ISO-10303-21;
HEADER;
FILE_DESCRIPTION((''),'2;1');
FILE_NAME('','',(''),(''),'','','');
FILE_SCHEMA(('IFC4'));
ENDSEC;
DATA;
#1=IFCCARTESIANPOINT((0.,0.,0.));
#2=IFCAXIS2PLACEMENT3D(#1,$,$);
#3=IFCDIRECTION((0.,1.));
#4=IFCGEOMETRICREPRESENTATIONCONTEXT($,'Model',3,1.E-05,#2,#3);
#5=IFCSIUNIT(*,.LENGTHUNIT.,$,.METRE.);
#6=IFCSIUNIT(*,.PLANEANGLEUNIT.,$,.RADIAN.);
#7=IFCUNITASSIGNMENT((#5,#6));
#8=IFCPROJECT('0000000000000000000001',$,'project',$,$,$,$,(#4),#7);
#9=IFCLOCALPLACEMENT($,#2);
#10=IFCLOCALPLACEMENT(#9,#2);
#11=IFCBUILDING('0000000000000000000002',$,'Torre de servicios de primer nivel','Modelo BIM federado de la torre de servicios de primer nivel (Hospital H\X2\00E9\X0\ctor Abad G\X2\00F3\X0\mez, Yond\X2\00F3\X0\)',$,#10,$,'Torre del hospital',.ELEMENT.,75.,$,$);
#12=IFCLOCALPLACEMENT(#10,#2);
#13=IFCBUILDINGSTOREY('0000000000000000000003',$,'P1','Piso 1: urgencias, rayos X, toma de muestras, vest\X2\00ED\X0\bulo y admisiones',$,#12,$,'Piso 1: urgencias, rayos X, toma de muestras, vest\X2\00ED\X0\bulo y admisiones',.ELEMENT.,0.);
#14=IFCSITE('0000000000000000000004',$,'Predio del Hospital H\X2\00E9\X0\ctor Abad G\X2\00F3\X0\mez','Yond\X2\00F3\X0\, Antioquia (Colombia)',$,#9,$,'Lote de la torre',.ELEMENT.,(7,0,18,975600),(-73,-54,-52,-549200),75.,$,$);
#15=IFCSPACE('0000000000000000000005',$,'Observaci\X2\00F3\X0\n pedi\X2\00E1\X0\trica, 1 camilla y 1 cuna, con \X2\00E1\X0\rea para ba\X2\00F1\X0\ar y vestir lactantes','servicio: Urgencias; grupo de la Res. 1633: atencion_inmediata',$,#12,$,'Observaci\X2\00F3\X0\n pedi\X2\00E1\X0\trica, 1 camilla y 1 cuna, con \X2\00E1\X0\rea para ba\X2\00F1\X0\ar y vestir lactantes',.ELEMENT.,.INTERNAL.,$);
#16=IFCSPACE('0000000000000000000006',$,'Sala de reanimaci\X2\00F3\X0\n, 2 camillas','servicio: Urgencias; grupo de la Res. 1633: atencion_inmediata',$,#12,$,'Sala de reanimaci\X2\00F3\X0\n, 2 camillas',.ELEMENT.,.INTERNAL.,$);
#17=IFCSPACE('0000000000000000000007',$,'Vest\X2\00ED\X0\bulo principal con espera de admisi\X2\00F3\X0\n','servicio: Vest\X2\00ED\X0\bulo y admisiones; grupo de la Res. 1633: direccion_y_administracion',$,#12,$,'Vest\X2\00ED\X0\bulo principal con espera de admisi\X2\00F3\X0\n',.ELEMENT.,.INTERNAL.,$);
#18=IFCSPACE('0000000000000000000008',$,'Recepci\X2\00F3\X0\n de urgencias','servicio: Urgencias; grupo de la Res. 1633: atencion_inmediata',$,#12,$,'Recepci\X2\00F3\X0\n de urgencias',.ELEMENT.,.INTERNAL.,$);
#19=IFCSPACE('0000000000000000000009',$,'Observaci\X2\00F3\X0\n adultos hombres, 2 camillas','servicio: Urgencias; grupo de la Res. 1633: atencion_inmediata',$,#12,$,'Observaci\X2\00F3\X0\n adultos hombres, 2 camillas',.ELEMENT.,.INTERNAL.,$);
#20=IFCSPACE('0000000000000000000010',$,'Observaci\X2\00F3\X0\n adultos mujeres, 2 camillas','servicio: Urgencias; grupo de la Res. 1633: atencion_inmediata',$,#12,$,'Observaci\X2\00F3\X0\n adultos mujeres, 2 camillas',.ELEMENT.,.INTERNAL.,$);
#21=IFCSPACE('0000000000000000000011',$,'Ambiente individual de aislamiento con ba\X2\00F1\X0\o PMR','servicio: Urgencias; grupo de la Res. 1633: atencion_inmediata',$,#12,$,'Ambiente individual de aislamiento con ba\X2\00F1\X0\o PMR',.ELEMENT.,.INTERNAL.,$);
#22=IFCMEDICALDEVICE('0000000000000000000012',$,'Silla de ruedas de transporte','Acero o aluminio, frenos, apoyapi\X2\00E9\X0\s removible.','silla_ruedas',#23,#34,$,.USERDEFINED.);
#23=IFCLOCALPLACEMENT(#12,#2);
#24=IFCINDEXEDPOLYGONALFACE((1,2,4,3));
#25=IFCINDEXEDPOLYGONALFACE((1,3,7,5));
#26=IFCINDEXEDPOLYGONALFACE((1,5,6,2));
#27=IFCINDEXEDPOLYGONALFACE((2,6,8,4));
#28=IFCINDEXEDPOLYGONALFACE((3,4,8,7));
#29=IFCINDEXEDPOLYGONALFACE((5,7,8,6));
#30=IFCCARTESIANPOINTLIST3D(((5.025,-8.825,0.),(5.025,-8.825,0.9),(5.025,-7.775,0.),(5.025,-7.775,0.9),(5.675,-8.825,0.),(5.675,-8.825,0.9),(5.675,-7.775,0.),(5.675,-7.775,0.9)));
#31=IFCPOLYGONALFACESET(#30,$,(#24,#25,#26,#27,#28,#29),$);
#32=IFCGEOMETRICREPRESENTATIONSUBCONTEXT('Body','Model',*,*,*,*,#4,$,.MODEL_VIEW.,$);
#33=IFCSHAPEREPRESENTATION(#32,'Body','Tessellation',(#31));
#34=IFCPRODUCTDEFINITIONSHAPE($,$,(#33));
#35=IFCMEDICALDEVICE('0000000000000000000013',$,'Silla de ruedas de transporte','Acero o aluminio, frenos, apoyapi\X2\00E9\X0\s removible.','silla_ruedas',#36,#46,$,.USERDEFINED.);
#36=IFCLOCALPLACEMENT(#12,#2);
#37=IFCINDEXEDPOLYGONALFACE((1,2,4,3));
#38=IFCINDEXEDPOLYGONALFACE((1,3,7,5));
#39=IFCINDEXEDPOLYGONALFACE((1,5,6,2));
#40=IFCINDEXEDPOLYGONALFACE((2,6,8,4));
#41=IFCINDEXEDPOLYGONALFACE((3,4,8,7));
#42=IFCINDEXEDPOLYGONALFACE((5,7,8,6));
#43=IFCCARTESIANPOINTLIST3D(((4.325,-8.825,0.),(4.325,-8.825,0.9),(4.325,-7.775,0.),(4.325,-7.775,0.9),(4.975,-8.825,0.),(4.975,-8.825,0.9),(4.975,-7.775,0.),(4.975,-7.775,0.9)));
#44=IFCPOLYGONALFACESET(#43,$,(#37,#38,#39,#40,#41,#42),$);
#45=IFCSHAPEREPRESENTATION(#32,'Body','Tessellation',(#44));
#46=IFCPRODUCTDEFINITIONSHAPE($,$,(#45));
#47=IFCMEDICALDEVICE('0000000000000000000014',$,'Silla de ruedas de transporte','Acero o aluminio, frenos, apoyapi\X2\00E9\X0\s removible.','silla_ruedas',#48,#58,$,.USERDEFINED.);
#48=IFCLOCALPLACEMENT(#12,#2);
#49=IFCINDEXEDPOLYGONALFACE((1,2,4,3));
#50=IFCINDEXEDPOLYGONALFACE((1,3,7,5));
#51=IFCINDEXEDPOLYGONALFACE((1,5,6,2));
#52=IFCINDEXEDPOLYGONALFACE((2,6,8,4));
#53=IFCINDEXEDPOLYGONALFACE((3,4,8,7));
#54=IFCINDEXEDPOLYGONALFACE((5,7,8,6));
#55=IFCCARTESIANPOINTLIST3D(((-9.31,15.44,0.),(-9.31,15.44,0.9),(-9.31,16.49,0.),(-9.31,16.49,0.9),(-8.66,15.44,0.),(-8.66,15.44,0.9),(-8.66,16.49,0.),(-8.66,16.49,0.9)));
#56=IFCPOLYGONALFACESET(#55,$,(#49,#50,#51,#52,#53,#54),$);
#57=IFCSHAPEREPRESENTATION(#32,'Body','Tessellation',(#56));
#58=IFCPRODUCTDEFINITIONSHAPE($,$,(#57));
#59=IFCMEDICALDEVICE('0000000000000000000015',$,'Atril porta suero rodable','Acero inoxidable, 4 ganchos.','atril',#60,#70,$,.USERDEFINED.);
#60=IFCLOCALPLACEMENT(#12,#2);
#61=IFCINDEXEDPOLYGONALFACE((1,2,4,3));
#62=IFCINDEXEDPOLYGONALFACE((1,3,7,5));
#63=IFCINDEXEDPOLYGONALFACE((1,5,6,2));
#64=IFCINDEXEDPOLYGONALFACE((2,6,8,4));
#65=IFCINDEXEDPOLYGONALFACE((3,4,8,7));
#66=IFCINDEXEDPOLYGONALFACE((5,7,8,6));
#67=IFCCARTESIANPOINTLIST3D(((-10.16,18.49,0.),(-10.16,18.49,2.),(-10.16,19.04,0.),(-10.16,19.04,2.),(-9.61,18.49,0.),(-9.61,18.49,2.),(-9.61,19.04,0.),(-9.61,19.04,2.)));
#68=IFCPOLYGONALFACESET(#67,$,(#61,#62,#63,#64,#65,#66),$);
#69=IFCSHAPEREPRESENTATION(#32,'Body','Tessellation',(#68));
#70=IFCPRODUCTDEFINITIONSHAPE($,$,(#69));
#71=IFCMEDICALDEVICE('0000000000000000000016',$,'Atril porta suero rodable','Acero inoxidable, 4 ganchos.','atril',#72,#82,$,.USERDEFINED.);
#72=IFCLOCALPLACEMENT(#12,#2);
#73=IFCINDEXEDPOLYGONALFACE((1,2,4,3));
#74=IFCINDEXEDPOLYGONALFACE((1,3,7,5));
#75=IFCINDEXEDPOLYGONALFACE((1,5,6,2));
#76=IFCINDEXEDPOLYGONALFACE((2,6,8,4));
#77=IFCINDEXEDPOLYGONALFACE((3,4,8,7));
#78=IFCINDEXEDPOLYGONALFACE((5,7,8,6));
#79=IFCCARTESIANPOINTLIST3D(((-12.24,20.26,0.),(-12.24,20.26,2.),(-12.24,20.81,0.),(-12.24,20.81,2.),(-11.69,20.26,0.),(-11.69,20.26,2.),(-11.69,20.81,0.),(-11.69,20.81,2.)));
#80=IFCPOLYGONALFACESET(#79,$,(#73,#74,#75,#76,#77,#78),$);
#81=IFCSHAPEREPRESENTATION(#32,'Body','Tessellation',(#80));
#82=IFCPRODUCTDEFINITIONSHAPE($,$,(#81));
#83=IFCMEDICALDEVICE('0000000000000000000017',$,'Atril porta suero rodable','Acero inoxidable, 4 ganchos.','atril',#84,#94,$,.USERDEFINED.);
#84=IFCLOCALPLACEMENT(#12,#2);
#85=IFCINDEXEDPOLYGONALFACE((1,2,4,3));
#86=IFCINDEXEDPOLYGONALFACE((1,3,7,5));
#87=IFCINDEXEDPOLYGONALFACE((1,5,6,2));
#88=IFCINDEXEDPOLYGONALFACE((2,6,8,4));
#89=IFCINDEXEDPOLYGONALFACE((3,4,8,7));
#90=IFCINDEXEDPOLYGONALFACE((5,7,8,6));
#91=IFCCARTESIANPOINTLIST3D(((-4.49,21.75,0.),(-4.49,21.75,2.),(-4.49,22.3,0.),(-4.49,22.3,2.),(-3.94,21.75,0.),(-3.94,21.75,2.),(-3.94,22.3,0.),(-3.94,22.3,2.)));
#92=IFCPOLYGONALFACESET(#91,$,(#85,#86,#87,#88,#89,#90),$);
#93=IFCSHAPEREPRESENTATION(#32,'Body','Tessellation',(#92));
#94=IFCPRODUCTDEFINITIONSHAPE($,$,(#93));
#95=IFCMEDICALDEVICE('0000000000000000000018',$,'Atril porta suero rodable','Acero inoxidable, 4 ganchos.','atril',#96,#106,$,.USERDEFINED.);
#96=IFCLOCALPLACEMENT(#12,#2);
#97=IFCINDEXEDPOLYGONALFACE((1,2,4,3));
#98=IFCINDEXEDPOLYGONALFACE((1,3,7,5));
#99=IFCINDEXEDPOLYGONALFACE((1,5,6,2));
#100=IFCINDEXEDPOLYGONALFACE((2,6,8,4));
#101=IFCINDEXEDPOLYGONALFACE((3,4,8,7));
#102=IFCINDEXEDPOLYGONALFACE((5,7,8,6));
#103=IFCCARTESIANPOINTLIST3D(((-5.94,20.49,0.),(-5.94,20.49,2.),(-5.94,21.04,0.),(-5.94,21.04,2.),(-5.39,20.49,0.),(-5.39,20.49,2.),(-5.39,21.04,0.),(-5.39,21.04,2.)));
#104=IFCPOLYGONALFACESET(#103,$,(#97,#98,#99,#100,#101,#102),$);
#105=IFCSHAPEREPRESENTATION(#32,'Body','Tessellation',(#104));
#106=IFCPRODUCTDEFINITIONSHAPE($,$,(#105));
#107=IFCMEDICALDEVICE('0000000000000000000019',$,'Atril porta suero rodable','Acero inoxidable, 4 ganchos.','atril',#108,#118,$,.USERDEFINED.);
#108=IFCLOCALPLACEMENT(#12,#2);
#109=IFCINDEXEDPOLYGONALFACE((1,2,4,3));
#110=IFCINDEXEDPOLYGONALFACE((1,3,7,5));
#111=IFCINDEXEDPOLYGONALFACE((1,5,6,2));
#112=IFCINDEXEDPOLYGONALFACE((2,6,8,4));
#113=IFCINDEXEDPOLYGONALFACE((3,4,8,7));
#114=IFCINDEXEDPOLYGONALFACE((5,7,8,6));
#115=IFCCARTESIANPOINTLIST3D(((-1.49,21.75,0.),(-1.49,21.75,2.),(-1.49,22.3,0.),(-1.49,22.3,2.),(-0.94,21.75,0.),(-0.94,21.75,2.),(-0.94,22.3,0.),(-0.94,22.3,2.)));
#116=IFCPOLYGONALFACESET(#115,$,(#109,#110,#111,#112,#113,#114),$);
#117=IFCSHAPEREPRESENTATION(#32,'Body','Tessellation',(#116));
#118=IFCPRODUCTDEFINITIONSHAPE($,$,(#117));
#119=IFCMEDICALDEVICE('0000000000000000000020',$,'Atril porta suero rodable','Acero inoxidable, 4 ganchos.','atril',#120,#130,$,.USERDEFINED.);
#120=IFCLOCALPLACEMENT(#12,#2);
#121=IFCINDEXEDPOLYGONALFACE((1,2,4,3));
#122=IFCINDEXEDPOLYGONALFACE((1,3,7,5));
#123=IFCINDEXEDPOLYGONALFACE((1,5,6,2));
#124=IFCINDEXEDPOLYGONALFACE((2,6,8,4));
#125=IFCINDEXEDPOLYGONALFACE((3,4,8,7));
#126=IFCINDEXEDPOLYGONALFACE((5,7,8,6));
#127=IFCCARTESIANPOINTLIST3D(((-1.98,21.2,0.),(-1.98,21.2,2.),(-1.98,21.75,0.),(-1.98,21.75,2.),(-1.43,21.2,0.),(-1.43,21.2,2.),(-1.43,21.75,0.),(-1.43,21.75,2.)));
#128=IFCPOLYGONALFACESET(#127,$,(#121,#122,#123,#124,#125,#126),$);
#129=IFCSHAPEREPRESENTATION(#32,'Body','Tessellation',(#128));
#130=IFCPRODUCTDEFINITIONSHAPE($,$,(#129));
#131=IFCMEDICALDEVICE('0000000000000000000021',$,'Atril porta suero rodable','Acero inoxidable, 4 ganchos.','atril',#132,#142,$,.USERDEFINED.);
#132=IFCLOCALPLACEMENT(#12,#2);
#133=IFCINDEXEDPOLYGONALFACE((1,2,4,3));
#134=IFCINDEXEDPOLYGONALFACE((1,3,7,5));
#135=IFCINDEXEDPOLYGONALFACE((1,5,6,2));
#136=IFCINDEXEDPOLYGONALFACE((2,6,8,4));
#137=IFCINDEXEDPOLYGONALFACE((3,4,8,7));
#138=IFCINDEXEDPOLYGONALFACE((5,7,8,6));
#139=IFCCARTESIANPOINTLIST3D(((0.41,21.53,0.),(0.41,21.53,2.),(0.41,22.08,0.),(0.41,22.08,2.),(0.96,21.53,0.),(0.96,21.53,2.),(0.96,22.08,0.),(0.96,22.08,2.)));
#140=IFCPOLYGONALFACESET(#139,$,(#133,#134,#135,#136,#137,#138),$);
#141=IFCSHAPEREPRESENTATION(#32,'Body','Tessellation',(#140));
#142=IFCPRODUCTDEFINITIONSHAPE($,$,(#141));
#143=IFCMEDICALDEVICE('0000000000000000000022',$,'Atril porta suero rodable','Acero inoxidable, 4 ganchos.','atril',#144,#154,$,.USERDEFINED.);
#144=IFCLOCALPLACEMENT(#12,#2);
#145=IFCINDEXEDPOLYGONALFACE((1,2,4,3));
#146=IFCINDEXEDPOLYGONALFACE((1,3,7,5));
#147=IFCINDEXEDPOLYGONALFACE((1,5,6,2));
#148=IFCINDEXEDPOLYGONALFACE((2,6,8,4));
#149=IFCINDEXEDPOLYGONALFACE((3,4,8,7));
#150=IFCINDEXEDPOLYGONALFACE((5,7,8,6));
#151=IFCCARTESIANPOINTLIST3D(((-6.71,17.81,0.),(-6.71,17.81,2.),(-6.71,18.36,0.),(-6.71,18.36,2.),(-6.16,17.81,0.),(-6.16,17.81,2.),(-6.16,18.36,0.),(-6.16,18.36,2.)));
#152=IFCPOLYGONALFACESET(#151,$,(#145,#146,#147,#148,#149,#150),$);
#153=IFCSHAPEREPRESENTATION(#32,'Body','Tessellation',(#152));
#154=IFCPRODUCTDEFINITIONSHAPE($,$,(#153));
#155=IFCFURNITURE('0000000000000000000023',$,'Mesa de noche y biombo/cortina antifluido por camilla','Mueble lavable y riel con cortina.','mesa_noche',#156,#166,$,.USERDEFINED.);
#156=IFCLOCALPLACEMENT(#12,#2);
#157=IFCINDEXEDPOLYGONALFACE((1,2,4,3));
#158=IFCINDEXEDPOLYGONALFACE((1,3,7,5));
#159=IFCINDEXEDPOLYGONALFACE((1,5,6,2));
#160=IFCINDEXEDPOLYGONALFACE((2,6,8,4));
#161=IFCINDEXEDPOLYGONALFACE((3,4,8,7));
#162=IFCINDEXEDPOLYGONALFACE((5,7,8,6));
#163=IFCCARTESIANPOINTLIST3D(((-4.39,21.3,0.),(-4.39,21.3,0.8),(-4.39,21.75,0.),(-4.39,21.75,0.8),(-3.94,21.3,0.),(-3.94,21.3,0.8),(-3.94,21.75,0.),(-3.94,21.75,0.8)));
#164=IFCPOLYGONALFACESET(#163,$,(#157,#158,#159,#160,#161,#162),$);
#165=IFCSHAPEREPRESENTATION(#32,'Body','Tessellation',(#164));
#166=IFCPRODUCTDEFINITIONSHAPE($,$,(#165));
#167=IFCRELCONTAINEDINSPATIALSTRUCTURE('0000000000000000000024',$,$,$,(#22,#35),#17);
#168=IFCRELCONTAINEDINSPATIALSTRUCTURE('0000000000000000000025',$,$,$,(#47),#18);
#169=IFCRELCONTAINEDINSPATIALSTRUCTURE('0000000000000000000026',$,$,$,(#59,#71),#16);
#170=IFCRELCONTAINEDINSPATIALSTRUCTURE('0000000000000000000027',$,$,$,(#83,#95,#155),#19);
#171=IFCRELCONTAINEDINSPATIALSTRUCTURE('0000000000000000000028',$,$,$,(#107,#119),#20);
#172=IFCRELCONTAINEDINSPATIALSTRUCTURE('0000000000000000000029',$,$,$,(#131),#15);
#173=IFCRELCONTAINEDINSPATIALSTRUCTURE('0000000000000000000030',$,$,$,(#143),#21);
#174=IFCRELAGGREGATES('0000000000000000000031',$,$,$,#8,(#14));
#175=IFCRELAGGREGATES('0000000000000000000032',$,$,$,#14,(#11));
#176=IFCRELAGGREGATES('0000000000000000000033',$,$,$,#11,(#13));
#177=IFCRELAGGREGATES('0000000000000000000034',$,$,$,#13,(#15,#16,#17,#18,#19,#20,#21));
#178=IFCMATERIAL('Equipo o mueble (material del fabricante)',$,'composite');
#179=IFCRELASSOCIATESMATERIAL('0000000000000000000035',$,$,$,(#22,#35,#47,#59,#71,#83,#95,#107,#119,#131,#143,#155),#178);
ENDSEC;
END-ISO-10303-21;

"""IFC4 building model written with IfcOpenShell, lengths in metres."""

from ifc_helpers import new_model, si_unit, direction, frame, origin, place, context, subcontext, project, spatial, rectangle, extrude, material, element, save


model = new_model("IFC4")

# Units and contexts
model_context = context("Model", 3, precision=1e-05, world=origin(), true_north=direction((0.0, 1.0)))
body_context = subcontext(model_context, "Body", "Model", "MODEL_VIEW")
ifc_project = project(units=[si_unit("LENGTHUNIT", "METRE"), si_unit("PLANEANGLEUNIT", "RADIAN")], contexts=[model_context])

# Site, building, storey
site_placement = place(None, origin())
site = spatial("IfcSite", under=ifc_project, at=site_placement, Name="Predio del Hospital Héctor Abad Gómez", Description="Yondó, Antioquia (Colombia)", LongName="Lote de la torre", CompositionType="ELEMENT", RefLatitude=(7, 0, 18, 975600), RefLongitude=(-73, -54, -52, -549200), RefElevation=75.0)
building_placement = place(site_placement, origin())
building = spatial("IfcBuilding", under=site, at=building_placement, Name="Torre de servicios de primer nivel", Description="Modelo BIM federado de la torre de servicios de primer nivel (Hospital Héctor Abad Gómez, Yondó)", LongName="Torre del hospital", CompositionType="ELEMENT", ElevationOfRefHeight=75.0)
placement = place(building_placement, origin())
storey = spatial("IfcBuildingStorey", under=building, at=placement, Name="P1", Description="Piso 1: urgencias, rayos X, toma de muestras, vestíbulo y admisiones", LongName="Piso 1: urgencias, rayos X, toma de muestras, vestíbulo y admisiones", CompositionType="ELEMENT", Elevation=0.0)

# Shared definitions
ifc_material = material(Name="Equipo o mueble (material del fabricante)", Category="composite")

# Shared definitions
space_1 = spatial("IfcSpace", under=storey, at=placement, Name="Observación pediátrica, 1 camilla y 1 cuna, con área para bañar y vestir lactantes", Description="servicio: Urgencias; grupo de la Res. 1633: atencion_inmediata", LongName="Observación pediátrica, 1 camilla y 1 cuna, con área para bañar y vestir lactantes", CompositionType="ELEMENT", PredefinedType="INTERNAL")

# Shared definitions
space_2 = spatial("IfcSpace", under=storey, at=placement, Name="Sala de reanimación, 2 camillas", Description="servicio: Urgencias; grupo de la Res. 1633: atencion_inmediata", LongName="Sala de reanimación, 2 camillas", CompositionType="ELEMENT", PredefinedType="INTERNAL")

# Shared definitions
space_3 = spatial("IfcSpace", under=storey, at=placement, Name="Vestíbulo principal con espera de admisión", Description="servicio: Vestíbulo y admisiones; grupo de la Res. 1633: direccion_y_administracion", LongName="Vestíbulo principal con espera de admisión", CompositionType="ELEMENT", PredefinedType="INTERNAL")

# Medical devices
element("IfcMedicalDevice", 1, at=placement, inside=space_3, material=ifc_material, Name="Silla de ruedas de transporte", Description="Acero o aluminio, frenos, apoyapiés removible.", ObjectType="silla_ruedas", PredefinedType="USERDEFINED", context=body_context, shape_type="SweptSolid", body=[
    extrude(rectangle(XDim=0.65, YDim=1.05), frame((5.35, -8.3, 0.0), z_axis=(0.0, 0.0, 1.0), x_axis=(-1.0, 0.0, 0.0)), (0.0, 0.0, 1.0), 0.9),
])
element("IfcMedicalDevice", 2, at=placement, inside=space_3, material=ifc_material, Name="Silla de ruedas de transporte", Description="Acero o aluminio, frenos, apoyapiés removible.", ObjectType="silla_ruedas", PredefinedType="USERDEFINED", context=body_context, shape_type="SweptSolid", body=[
    extrude(rectangle(XDim=0.65, YDim=1.05), frame((4.65, -8.3, 0.0), z_axis=(0.0, 0.0, 1.0), x_axis=(-1.0, 0.0, 0.0)), (0.0, 0.0, 1.0), 0.9),
])

# Shared definitions
space_4 = spatial("IfcSpace", under=storey, at=placement, Name="Recepción de urgencias", Description="servicio: Urgencias; grupo de la Res. 1633: atencion_inmediata", LongName="Recepción de urgencias", CompositionType="ELEMENT", PredefinedType="INTERNAL")

# Medical devices
element("IfcMedicalDevice", 3, at=placement, inside=space_4, material=ifc_material, Name="Silla de ruedas de transporte", Description="Acero o aluminio, frenos, apoyapiés removible.", ObjectType="silla_ruedas", PredefinedType="USERDEFINED", context=body_context, shape_type="SweptSolid", body=[
    extrude(rectangle(XDim=0.65, YDim=1.05), frame((-8.985, 15.965, 0.0), z_axis=(0.0, 0.0, 1.0), x_axis=(-1.0, 0.0, 0.0)), (0.0, 0.0, 1.0), 0.9),
])
element("IfcMedicalDevice", 4, at=placement, inside=space_2, material=ifc_material, Name="Atril porta suero rodable", Description="Acero inoxidable, 4 ganchos.", ObjectType="atril", PredefinedType="USERDEFINED", context=body_context, shape_type="SweptSolid", body=[
    extrude(rectangle(XDim=0.55, YDim=0.55), frame((-9.885, 18.765, 0.0), z_axis=(0.0, 0.0, 1.0), x_axis=(0.0, 1.0, 0.0)), (0.0, 0.0, 1.0), 2.0),
])
element("IfcMedicalDevice", 5, at=placement, inside=space_2, material=ifc_material, Name="Atril porta suero rodable", Description="Acero inoxidable, 4 ganchos.", ObjectType="atril", PredefinedType="USERDEFINED", context=body_context, shape_type="SweptSolid", body=[
    extrude(rectangle(XDim=0.55, YDim=0.55), frame((-11.965, 20.535, 0.0), z_axis=(0.0, 0.0, 1.0), x_axis=(0.0, 1.0, 0.0)), (0.0, 0.0, 1.0), 2.0),
])

# Shared definitions
space_5 = spatial("IfcSpace", under=storey, at=placement, Name="Observación adultos hombres, 2 camillas", Description="servicio: Urgencias; grupo de la Res. 1633: atencion_inmediata", LongName="Observación adultos hombres, 2 camillas", CompositionType="ELEMENT", PredefinedType="INTERNAL")

# Medical devices
element("IfcMedicalDevice", 6, at=placement, inside=space_5, material=ifc_material, Name="Atril porta suero rodable", Description="Acero inoxidable, 4 ganchos.", ObjectType="atril", PredefinedType="USERDEFINED", context=body_context, shape_type="SweptSolid", body=[
    extrude(rectangle(XDim=0.55, YDim=0.55), frame((-4.215, 22.025, 0.0), z_axis=(0.0, 0.0, 1.0), x_axis=(-1.0, 0.0, 0.0)), (0.0, 0.0, 1.0), 2.0),
])
element("IfcMedicalDevice", 7, at=placement, inside=space_5, material=ifc_material, Name="Atril porta suero rodable", Description="Acero inoxidable, 4 ganchos.", ObjectType="atril", PredefinedType="USERDEFINED", context=body_context, shape_type="SweptSolid", body=[
    extrude(rectangle(XDim=0.55, YDim=0.55), frame((-5.665, 20.765, 0.0)), (0.0, 0.0, 1.0), 2.0),
])

# Shared definitions
space_6 = spatial("IfcSpace", under=storey, at=placement, Name="Observación adultos mujeres, 2 camillas", Description="servicio: Urgencias; grupo de la Res. 1633: atencion_inmediata", LongName="Observación adultos mujeres, 2 camillas", CompositionType="ELEMENT", PredefinedType="INTERNAL")

# Medical devices
element("IfcMedicalDevice", 8, at=placement, inside=space_6, material=ifc_material, Name="Atril porta suero rodable", Description="Acero inoxidable, 4 ganchos.", ObjectType="atril", PredefinedType="USERDEFINED", context=body_context, shape_type="SweptSolid", body=[
    extrude(rectangle(XDim=0.55, YDim=0.55), frame((-1.215, 22.025, 0.0), z_axis=(0.0, 0.0, 1.0), x_axis=(-1.0, 0.0, 0.0)), (0.0, 0.0, 1.0), 2.0),
])
element("IfcMedicalDevice", 9, at=placement, inside=space_6, material=ifc_material, Name="Atril porta suero rodable", Description="Acero inoxidable, 4 ganchos.", ObjectType="atril", PredefinedType="USERDEFINED", context=body_context, shape_type="SweptSolid", body=[
    extrude(rectangle(XDim=0.55, YDim=0.55), frame((-1.705, 21.475, 0.0), z_axis=(0.0, 0.0, 1.0), x_axis=(-1.0, 0.0, 0.0)), (0.0, 0.0, 1.0), 2.0),
])
element("IfcMedicalDevice", 10, at=placement, inside=space_1, material=ifc_material, Name="Atril porta suero rodable", Description="Acero inoxidable, 4 ganchos.", ObjectType="atril", PredefinedType="USERDEFINED", context=body_context, shape_type="SweptSolid", body=[
    extrude(rectangle(XDim=0.55, YDim=0.55), frame((0.685, 21.805, 0.0), z_axis=(0.0, 0.0, 1.0), x_axis=(0.0, -1.0, 0.0)), (0.0, 0.0, 1.0), 2.0),
])

# Shared definitions
space_7 = spatial("IfcSpace", under=storey, at=placement, Name="Ambiente individual de aislamiento con baño PMR", Description="servicio: Urgencias; grupo de la Res. 1633: atencion_inmediata", LongName="Ambiente individual de aislamiento con baño PMR", CompositionType="ELEMENT", PredefinedType="INTERNAL")

# Medical device
element("IfcMedicalDevice", 11, at=placement, inside=space_7, material=ifc_material, Name="Atril porta suero rodable", Description="Acero inoxidable, 4 ganchos.", ObjectType="atril", PredefinedType="USERDEFINED", context=body_context, shape_type="SweptSolid", body=[
    extrude(rectangle(XDim=0.55, YDim=0.55), frame((-6.435, 18.085, 0.0), z_axis=(0.0, 0.0, 1.0), x_axis=(0.0, 1.0, 0.0)), (0.0, 0.0, 1.0), 2.0),
])

# Furniture
element("IfcFurniture", 12, at=placement, inside=space_5, material=ifc_material, Name="Mesa de noche y biombo/cortina antifluido por camilla", Description="Mueble lavable y riel con cortina.", ObjectType="mesa_noche", PredefinedType="USERDEFINED", context=body_context, shape_type="SweptSolid", body=[
    extrude(rectangle(XDim=0.45, YDim=0.45), frame((-4.165, 21.525, 0.0), z_axis=(0.0, 0.0, 1.0), x_axis=(-1.0, 0.0, 0.0)), (0.0, 0.0, 1.0), 0.8),
])

save(model, "model.ifc")
